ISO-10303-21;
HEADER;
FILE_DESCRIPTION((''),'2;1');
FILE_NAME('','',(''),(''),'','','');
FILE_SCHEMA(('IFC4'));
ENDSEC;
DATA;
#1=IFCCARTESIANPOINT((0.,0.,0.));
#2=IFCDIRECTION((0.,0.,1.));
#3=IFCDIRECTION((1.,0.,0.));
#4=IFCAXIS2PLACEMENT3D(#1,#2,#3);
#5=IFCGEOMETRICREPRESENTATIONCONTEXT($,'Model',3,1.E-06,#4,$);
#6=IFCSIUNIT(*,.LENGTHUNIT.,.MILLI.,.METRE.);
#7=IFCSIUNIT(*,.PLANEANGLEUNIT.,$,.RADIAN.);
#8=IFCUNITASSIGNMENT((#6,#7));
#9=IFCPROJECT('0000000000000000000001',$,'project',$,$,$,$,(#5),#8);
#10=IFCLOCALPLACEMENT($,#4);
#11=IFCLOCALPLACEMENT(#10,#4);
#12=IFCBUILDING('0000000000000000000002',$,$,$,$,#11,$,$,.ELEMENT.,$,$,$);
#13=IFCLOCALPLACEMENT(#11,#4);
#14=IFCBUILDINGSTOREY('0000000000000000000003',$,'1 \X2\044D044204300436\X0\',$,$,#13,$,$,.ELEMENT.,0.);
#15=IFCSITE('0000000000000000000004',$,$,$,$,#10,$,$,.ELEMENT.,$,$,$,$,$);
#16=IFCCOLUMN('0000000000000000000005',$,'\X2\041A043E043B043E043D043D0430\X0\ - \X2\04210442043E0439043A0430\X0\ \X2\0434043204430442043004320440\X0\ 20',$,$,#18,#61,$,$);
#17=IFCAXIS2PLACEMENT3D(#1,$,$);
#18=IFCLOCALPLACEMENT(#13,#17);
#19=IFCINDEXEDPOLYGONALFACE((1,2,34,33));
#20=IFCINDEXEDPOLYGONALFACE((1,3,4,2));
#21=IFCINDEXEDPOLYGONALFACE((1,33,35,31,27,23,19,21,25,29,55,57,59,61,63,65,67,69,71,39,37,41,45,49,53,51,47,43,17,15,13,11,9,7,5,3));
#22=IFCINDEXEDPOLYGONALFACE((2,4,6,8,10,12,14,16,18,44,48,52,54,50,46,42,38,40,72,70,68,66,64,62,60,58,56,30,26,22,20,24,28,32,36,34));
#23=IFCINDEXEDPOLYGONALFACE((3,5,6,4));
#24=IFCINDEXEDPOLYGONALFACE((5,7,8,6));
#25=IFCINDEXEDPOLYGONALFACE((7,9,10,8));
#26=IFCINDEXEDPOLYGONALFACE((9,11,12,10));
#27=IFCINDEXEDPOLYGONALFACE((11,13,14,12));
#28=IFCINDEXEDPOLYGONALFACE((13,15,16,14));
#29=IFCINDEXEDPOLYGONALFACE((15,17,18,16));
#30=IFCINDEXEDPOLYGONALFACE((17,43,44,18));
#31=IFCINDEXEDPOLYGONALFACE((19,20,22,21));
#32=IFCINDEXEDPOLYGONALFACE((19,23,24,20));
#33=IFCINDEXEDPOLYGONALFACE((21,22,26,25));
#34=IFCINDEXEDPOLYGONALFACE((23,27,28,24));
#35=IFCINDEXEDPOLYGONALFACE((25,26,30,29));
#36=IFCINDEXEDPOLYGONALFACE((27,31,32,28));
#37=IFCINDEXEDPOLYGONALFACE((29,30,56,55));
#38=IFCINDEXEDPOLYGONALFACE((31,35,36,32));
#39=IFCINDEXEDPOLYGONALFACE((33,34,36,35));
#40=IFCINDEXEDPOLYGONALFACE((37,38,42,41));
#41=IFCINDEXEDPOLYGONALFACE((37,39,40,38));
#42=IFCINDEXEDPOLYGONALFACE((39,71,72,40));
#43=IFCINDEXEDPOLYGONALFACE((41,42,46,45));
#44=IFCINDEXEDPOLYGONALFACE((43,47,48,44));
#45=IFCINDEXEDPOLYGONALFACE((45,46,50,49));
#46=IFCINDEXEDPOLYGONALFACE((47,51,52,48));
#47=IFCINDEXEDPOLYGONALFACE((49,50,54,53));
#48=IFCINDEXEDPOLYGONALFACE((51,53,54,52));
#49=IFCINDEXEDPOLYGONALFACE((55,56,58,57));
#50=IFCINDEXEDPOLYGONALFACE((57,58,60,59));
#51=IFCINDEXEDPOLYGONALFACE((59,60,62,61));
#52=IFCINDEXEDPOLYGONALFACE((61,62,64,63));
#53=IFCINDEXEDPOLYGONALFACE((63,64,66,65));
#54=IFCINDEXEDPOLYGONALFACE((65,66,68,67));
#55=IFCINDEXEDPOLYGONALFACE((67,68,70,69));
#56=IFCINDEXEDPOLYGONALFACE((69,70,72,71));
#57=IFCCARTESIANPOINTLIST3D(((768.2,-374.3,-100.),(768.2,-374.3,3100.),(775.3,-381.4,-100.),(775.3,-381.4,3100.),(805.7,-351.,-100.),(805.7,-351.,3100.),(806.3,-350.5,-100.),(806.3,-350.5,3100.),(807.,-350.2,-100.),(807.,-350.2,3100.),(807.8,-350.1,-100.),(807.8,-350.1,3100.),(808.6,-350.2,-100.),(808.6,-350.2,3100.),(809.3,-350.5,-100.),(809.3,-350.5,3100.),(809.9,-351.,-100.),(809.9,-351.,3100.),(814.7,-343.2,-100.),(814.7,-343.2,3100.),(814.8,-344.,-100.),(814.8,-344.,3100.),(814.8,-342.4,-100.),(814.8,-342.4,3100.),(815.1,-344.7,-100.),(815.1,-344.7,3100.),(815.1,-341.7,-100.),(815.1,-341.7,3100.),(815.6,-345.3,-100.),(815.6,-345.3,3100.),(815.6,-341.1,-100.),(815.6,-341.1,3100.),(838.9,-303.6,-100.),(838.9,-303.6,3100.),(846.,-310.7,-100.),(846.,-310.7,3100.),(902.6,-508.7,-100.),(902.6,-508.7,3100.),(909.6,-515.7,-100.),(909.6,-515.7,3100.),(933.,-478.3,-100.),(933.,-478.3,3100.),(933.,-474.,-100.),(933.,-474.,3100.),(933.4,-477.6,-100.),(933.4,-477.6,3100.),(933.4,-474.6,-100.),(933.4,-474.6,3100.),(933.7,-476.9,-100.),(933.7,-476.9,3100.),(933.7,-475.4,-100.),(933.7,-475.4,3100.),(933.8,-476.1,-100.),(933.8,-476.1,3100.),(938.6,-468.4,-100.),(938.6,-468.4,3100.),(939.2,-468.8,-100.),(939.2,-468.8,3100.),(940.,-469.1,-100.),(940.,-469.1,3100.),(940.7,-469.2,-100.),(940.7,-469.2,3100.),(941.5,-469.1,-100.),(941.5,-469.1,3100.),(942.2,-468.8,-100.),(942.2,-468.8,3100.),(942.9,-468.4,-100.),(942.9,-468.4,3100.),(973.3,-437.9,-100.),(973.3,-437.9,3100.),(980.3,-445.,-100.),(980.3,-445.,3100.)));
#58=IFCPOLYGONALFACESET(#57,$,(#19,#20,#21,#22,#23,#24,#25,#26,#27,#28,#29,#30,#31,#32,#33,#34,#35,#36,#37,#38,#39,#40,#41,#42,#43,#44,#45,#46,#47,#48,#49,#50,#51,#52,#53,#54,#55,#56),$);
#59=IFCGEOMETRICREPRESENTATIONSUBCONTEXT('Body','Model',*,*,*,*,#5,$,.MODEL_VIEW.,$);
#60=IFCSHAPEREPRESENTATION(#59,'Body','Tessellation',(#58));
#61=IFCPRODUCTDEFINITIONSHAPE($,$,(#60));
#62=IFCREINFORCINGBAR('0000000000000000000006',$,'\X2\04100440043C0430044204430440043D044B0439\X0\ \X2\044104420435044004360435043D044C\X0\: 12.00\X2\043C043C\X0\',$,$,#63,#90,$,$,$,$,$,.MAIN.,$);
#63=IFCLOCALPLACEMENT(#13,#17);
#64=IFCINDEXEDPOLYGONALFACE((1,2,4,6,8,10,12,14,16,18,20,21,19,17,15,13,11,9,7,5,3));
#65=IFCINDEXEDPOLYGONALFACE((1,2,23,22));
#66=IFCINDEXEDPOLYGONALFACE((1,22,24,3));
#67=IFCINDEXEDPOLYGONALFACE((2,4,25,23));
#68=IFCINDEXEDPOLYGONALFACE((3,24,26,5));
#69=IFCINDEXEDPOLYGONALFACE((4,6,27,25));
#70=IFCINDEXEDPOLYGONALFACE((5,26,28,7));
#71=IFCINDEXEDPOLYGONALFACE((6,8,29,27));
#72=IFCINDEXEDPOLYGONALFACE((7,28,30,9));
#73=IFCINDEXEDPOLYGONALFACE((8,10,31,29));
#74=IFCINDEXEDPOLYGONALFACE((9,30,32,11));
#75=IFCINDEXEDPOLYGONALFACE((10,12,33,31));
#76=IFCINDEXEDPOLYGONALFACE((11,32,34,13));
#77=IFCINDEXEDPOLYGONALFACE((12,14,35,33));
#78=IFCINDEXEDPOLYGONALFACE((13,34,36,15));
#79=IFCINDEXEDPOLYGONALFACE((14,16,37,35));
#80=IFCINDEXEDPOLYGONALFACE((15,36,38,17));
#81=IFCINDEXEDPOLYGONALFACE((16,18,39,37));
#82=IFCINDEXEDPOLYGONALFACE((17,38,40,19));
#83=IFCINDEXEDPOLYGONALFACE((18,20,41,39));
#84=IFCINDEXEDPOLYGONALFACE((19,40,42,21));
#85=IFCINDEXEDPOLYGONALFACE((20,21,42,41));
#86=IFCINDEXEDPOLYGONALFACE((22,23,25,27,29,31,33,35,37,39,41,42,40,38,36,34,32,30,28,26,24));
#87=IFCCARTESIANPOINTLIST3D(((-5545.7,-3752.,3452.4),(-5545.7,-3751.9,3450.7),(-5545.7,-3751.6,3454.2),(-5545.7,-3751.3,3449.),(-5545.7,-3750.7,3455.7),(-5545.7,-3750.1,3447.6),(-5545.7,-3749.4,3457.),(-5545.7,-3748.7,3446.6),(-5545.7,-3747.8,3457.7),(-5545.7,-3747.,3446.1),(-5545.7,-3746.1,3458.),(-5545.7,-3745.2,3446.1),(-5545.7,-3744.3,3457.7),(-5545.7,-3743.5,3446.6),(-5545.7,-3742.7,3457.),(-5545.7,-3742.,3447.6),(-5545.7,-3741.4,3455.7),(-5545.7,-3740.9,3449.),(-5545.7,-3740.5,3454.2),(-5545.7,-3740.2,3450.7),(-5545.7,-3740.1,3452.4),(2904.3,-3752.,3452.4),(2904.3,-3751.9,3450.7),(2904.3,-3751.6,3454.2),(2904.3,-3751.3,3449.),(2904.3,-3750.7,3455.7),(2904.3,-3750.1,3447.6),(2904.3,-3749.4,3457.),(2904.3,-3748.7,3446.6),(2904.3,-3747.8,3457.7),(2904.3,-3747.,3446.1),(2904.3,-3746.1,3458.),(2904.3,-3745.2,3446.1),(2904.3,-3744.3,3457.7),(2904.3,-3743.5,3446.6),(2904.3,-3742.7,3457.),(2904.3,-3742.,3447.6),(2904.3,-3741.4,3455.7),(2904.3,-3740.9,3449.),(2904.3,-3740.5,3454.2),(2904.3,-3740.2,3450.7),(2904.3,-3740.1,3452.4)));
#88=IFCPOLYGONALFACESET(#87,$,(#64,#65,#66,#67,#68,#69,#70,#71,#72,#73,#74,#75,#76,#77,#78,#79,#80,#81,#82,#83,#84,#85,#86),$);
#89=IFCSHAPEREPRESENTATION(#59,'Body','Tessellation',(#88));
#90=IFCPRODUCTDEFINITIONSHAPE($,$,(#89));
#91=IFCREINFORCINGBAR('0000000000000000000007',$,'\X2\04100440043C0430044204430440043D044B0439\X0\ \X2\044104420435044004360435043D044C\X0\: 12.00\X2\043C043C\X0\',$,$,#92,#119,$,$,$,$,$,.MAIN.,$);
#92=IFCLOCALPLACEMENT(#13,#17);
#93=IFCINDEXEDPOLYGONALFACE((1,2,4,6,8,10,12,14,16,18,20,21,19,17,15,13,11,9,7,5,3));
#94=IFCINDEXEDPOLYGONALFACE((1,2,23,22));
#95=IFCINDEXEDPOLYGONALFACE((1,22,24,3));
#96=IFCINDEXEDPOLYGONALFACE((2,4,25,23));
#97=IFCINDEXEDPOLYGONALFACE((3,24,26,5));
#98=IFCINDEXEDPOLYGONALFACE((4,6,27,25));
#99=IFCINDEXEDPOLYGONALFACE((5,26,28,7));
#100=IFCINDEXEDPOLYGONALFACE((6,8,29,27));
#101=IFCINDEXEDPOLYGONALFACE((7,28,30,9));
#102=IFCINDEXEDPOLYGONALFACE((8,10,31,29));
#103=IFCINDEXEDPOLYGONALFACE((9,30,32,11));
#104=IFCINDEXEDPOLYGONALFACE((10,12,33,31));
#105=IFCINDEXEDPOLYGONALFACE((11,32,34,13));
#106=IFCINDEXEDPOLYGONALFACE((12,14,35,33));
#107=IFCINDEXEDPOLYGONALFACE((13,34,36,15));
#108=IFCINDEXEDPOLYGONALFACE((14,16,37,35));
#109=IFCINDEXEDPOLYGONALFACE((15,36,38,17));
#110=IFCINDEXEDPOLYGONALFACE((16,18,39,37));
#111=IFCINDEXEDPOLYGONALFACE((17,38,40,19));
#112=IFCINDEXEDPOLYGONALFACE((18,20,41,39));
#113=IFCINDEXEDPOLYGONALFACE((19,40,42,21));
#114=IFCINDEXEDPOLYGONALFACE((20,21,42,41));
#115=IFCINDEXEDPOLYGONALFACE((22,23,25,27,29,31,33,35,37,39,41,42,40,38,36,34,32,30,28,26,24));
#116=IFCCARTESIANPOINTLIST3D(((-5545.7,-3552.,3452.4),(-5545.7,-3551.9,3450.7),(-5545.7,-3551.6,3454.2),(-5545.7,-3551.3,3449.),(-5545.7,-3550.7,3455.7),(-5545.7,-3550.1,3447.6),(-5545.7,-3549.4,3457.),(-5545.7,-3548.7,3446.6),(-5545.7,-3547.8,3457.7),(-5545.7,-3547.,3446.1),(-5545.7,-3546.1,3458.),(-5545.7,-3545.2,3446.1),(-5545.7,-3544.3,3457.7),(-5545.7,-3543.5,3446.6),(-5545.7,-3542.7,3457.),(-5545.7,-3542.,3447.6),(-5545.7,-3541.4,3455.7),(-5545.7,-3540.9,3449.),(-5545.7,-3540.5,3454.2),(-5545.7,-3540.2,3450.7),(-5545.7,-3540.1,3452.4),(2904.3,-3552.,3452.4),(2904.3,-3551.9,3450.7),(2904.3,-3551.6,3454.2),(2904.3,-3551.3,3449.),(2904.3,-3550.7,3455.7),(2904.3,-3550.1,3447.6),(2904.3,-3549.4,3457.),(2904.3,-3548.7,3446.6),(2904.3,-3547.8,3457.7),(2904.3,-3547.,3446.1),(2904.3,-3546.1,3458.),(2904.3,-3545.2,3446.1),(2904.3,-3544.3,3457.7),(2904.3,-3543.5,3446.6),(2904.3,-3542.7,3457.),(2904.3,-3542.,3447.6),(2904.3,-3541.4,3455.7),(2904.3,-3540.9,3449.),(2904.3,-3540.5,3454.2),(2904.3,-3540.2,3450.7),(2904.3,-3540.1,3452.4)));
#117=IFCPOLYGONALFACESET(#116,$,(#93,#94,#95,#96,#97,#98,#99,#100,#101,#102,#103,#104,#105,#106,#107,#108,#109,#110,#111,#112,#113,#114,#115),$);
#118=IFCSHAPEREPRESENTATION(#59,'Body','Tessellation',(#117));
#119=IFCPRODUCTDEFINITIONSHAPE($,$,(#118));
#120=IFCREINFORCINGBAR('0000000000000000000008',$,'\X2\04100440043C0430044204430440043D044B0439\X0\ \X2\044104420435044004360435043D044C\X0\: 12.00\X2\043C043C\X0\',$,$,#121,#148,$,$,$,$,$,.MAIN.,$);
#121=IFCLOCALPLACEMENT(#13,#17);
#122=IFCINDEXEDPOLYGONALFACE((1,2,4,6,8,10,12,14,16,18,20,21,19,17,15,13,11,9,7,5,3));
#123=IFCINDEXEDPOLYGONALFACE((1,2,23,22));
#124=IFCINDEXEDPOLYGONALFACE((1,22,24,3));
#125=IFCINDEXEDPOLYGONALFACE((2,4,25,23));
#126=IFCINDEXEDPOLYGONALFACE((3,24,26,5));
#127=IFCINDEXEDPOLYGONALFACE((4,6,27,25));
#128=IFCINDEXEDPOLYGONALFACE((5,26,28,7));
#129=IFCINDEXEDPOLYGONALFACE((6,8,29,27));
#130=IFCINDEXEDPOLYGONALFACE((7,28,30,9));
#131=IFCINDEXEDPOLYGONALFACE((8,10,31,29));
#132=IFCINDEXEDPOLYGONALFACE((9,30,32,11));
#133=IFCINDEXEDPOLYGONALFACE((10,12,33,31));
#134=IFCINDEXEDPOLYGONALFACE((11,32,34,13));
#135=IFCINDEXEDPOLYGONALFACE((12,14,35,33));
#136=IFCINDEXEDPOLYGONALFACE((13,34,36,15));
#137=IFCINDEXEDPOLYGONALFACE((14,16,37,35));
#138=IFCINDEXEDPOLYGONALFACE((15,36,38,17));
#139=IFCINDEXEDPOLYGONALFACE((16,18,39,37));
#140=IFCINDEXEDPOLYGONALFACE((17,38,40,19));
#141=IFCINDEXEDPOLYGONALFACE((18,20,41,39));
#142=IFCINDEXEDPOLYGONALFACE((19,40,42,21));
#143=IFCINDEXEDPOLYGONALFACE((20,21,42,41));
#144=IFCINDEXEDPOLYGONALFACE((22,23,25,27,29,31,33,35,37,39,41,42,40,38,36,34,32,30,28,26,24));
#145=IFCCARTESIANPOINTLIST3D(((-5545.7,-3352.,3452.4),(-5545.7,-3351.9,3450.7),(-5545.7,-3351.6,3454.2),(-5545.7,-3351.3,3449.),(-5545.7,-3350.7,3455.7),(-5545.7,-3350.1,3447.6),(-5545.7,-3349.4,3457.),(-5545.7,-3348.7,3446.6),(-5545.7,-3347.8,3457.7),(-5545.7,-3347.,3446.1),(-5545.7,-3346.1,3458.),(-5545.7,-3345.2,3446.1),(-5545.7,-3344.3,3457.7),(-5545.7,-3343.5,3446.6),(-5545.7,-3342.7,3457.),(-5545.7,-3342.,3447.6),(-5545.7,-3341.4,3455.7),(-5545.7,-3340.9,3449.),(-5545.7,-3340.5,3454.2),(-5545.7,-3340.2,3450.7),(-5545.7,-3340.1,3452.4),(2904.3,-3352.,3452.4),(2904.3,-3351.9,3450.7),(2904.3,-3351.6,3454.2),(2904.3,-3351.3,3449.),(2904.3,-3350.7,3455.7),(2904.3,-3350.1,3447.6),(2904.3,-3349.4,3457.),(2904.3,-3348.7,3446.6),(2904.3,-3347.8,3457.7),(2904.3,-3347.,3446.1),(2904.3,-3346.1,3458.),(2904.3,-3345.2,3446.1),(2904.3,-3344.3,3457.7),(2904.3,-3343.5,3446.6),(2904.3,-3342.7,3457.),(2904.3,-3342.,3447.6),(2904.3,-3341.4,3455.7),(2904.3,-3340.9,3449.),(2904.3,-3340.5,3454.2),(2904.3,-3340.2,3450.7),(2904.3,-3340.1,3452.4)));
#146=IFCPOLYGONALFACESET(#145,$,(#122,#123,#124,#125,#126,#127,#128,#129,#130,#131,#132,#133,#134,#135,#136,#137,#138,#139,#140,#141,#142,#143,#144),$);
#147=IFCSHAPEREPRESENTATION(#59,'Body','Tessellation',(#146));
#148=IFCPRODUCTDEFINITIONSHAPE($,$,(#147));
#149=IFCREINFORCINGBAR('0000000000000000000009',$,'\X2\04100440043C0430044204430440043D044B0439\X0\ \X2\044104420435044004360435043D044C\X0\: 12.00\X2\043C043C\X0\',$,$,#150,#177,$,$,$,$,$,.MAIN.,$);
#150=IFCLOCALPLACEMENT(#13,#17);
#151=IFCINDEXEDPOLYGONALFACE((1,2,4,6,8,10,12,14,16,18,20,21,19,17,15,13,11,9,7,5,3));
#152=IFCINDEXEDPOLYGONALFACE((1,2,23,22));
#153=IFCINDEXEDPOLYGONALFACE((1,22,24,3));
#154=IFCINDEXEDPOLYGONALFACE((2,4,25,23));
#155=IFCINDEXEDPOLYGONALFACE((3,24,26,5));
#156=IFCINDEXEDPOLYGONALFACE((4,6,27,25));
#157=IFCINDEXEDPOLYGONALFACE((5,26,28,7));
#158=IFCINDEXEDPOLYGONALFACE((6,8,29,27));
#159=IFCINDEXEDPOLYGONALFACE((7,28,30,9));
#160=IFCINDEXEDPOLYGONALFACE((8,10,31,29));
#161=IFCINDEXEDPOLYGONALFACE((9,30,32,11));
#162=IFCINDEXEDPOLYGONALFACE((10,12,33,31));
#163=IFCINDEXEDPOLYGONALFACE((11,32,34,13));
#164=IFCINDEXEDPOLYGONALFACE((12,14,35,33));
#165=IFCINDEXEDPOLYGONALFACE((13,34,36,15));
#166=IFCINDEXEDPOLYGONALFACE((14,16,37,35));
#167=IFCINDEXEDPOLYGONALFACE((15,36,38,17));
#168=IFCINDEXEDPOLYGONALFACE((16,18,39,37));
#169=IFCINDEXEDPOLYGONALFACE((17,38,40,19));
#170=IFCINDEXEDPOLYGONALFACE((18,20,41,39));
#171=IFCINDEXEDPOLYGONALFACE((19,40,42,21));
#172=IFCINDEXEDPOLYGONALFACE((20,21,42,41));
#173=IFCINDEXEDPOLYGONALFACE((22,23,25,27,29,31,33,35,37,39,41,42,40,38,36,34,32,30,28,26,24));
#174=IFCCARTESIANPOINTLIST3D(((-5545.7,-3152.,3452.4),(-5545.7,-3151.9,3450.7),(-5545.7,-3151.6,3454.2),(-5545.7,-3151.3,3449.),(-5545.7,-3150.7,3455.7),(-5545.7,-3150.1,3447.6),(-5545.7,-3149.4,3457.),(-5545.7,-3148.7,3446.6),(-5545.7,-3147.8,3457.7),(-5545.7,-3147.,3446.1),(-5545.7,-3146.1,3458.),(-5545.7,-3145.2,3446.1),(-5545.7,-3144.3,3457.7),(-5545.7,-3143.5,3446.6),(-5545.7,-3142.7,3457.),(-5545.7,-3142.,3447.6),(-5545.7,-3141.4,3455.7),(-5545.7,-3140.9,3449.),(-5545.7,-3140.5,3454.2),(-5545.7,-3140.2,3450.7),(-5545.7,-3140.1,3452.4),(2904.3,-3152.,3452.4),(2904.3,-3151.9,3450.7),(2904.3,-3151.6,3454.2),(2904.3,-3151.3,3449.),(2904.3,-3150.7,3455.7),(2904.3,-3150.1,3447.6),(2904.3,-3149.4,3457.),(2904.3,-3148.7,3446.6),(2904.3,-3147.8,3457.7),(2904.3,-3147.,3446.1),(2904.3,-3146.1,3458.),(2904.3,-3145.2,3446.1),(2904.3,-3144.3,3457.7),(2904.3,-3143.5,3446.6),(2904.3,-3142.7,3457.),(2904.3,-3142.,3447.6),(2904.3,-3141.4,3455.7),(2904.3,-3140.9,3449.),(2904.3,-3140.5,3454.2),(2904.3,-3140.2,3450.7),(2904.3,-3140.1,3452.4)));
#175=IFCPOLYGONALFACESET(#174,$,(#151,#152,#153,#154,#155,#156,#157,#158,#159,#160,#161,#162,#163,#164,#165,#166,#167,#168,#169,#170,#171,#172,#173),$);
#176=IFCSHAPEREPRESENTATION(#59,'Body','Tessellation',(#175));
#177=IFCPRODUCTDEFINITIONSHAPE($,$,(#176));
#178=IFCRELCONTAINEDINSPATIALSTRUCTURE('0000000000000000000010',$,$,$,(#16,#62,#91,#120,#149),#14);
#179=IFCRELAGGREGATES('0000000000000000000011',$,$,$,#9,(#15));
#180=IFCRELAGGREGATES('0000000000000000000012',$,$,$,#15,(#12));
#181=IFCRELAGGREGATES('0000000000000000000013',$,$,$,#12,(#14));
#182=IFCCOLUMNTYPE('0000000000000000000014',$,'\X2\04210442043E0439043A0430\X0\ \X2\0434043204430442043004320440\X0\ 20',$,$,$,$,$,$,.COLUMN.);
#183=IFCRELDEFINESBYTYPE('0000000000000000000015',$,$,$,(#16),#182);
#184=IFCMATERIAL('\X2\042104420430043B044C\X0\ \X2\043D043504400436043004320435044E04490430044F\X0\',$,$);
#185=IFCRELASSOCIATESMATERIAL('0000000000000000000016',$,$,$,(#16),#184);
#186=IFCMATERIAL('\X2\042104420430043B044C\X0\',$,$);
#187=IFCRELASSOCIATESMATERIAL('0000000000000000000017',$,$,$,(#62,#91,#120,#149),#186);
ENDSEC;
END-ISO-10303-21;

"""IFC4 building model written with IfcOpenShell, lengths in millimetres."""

from ifc_helpers import new_model, entity, si_unit, frame, origin_with_axes, place, context, subcontext, project, spatial, line, arc, indexed_curve, outline, extrude, source, transform, mapped, material, type_object, element, save


model = new_model("IFC4")

# Units and contexts
model_context = context("Model", 3, precision=1e-06, world=origin_with_axes())
body_context = subcontext(model_context, "Body", "Model", "MODEL_VIEW")
ifc_project = project(units=[si_unit("LENGTHUNIT", "METRE", prefix="MILLI"), si_unit("PLANEANGLEUNIT", "RADIAN")], contexts=[model_context])

# Site, building, storey
site_placement = place(None, origin_with_axes())
site = spatial("IfcSite", under=ifc_project, at=site_placement, CompositionType="ELEMENT")
building_placement = place(site_placement, origin_with_axes())
building = spatial("IfcBuilding", under=site, at=building_placement, CompositionType="ELEMENT")
storey_placement = place(building_placement, origin_with_axes())
storey = spatial("IfcBuildingStorey", under=building, at=storey_placement, Name="1 этаж", CompositionType="ELEMENT", Elevation=0.0)

# Column
ifc_material_1 = material(Name="Сталь нержавеющая")
column_type = type_object("IfcColumnType", Name="Стойка двутавр 20", PredefinedType="COLUMN")
shared_shape_1 = source(origin_with_axes(), body_context, "Body", "SweptSolid", [
    extrude(outline(indexed_curve([(-50.0, -100.0), (50.0, -100.0), (50.0, -90.0), (7.0, -90.0), (4.9, -89.1), (4.0, -87.0), (4.0, 87.0), (4.9, 89.1), (7.0, 90.0), (50.0, 90.0), (50.0, 100.0), (-50.0, 100.0), (-50.0, 90.0), (-7.0, 90.0), (-4.9, 89.1), (-4.0, 87.0), (-4.0, -87.0), (-4.9, -89.1), (-7.0, -90.0), (-50.0, -90.0)], segments=[line(1, 2), line(2, 3), line(3, 4), arc(4, 5, 6), line(6, 7), arc(7, 8, 9), line(9, 10), line(10, 11), line(11, 12), line(12, 13), line(13, 14), arc(14, 15, 16), line(16, 17), arc(17, 18, 19), line(19, 20), line(20, 1)])), origin_with_axes(), (0.0, 0.0, 1.0), 3200.0),
])
column_placement = place(storey_placement, frame((874.3, -409.7, -100.0), z_axis=(0.0, 0.0, 1.0), x_axis=(0.707107, 0.707107, 0.0)))
element("IfcColumn", 1, at=column_placement, inside=storey, type_object=column_type, material=ifc_material_1, Name="Колонна - Стойка двутавр 20", context=body_context, shape_type="MappedRepresentation", body=[
    mapped(shared_shape_1, transform((0.0, 0.0, 0.0), x_axis=(1.0, 0.0, 0.0), y_axis=(0.0, 1.0, 0.0), z_axis=(0.0, 0.0, 1.0), scale=1.0)),
])

# Reinforcing bars
ifc_material_2 = material(Name="Сталь")
shared_shape_2 = source(origin_with_axes(), body_context, "Body", "AdvancedSweptSolid", [
    entity("IfcSweptDiskSolid", entity("IfcIndexedPolyCurve", entity("IfcCartesianPointList3D", [[0.0, 0.0, 0.0], [8450.0, 0.0, 0.0]]), [entity("IfcLineIndex", [1, 2])]), 6.0),
])
reinforcing_bar_1_placement = place(storey_placement, origin_with_axes())
element("IfcReinforcingBar", 2, at=reinforcing_bar_1_placement, inside=storey, material=ifc_material_2, Name="Арматурный стержень: 12.00мм", PredefinedType="MAIN", context=body_context, shape_type="MappedRepresentation", body=[
    mapped(shared_shape_2, transform((-5545.7, -3746.1, 3452.0), x_axis=(1.0, 0.0, 0.0), y_axis=(0.0, 1.0, 0.0), z_axis=(0.0, 0.0, 1.0), scale=1.0)),
])
reinforcing_bar_2_placement = place(storey_placement, origin_with_axes())
element("IfcReinforcingBar", 3, at=reinforcing_bar_2_placement, inside=storey, material=ifc_material_2, Name="Арматурный стержень: 12.00мм", PredefinedType="MAIN", context=body_context, shape_type="MappedRepresentation", body=[
    mapped(shared_shape_2, transform((-5545.7, -3546.1, 3452.0), x_axis=(1.0, 0.0, 0.0), y_axis=(0.0, 1.0, 0.0), z_axis=(0.0, 0.0, 1.0), scale=1.0)),
])
reinforcing_bar_3_placement = place(storey_placement, origin_with_axes())
element("IfcReinforcingBar", 4, at=reinforcing_bar_3_placement, inside=storey, material=ifc_material_2, Name="Арматурный стержень: 12.00мм", PredefinedType="MAIN", context=body_context, shape_type="MappedRepresentation", body=[
    mapped(shared_shape_2, transform((-5545.7, -3346.1, 3452.0), x_axis=(1.0, 0.0, 0.0), y_axis=(0.0, 1.0, 0.0), z_axis=(0.0, 0.0, 1.0), scale=1.0)),
])
reinforcing_bar_4_placement = place(storey_placement, origin_with_axes())
element("IfcReinforcingBar", 5, at=reinforcing_bar_4_placement, inside=storey, material=ifc_material_2, Name="Арматурный стержень: 12.00мм", PredefinedType="MAIN", context=body_context, shape_type="MappedRepresentation", body=[
    mapped(shared_shape_2, transform((-5545.7, -3146.1, 3452.0), x_axis=(1.0, 0.0, 0.0), y_axis=(0.0, 1.0, 0.0), z_axis=(0.0, 0.0, 1.0), scale=1.0)),
])

save(model, "model.ifc")
